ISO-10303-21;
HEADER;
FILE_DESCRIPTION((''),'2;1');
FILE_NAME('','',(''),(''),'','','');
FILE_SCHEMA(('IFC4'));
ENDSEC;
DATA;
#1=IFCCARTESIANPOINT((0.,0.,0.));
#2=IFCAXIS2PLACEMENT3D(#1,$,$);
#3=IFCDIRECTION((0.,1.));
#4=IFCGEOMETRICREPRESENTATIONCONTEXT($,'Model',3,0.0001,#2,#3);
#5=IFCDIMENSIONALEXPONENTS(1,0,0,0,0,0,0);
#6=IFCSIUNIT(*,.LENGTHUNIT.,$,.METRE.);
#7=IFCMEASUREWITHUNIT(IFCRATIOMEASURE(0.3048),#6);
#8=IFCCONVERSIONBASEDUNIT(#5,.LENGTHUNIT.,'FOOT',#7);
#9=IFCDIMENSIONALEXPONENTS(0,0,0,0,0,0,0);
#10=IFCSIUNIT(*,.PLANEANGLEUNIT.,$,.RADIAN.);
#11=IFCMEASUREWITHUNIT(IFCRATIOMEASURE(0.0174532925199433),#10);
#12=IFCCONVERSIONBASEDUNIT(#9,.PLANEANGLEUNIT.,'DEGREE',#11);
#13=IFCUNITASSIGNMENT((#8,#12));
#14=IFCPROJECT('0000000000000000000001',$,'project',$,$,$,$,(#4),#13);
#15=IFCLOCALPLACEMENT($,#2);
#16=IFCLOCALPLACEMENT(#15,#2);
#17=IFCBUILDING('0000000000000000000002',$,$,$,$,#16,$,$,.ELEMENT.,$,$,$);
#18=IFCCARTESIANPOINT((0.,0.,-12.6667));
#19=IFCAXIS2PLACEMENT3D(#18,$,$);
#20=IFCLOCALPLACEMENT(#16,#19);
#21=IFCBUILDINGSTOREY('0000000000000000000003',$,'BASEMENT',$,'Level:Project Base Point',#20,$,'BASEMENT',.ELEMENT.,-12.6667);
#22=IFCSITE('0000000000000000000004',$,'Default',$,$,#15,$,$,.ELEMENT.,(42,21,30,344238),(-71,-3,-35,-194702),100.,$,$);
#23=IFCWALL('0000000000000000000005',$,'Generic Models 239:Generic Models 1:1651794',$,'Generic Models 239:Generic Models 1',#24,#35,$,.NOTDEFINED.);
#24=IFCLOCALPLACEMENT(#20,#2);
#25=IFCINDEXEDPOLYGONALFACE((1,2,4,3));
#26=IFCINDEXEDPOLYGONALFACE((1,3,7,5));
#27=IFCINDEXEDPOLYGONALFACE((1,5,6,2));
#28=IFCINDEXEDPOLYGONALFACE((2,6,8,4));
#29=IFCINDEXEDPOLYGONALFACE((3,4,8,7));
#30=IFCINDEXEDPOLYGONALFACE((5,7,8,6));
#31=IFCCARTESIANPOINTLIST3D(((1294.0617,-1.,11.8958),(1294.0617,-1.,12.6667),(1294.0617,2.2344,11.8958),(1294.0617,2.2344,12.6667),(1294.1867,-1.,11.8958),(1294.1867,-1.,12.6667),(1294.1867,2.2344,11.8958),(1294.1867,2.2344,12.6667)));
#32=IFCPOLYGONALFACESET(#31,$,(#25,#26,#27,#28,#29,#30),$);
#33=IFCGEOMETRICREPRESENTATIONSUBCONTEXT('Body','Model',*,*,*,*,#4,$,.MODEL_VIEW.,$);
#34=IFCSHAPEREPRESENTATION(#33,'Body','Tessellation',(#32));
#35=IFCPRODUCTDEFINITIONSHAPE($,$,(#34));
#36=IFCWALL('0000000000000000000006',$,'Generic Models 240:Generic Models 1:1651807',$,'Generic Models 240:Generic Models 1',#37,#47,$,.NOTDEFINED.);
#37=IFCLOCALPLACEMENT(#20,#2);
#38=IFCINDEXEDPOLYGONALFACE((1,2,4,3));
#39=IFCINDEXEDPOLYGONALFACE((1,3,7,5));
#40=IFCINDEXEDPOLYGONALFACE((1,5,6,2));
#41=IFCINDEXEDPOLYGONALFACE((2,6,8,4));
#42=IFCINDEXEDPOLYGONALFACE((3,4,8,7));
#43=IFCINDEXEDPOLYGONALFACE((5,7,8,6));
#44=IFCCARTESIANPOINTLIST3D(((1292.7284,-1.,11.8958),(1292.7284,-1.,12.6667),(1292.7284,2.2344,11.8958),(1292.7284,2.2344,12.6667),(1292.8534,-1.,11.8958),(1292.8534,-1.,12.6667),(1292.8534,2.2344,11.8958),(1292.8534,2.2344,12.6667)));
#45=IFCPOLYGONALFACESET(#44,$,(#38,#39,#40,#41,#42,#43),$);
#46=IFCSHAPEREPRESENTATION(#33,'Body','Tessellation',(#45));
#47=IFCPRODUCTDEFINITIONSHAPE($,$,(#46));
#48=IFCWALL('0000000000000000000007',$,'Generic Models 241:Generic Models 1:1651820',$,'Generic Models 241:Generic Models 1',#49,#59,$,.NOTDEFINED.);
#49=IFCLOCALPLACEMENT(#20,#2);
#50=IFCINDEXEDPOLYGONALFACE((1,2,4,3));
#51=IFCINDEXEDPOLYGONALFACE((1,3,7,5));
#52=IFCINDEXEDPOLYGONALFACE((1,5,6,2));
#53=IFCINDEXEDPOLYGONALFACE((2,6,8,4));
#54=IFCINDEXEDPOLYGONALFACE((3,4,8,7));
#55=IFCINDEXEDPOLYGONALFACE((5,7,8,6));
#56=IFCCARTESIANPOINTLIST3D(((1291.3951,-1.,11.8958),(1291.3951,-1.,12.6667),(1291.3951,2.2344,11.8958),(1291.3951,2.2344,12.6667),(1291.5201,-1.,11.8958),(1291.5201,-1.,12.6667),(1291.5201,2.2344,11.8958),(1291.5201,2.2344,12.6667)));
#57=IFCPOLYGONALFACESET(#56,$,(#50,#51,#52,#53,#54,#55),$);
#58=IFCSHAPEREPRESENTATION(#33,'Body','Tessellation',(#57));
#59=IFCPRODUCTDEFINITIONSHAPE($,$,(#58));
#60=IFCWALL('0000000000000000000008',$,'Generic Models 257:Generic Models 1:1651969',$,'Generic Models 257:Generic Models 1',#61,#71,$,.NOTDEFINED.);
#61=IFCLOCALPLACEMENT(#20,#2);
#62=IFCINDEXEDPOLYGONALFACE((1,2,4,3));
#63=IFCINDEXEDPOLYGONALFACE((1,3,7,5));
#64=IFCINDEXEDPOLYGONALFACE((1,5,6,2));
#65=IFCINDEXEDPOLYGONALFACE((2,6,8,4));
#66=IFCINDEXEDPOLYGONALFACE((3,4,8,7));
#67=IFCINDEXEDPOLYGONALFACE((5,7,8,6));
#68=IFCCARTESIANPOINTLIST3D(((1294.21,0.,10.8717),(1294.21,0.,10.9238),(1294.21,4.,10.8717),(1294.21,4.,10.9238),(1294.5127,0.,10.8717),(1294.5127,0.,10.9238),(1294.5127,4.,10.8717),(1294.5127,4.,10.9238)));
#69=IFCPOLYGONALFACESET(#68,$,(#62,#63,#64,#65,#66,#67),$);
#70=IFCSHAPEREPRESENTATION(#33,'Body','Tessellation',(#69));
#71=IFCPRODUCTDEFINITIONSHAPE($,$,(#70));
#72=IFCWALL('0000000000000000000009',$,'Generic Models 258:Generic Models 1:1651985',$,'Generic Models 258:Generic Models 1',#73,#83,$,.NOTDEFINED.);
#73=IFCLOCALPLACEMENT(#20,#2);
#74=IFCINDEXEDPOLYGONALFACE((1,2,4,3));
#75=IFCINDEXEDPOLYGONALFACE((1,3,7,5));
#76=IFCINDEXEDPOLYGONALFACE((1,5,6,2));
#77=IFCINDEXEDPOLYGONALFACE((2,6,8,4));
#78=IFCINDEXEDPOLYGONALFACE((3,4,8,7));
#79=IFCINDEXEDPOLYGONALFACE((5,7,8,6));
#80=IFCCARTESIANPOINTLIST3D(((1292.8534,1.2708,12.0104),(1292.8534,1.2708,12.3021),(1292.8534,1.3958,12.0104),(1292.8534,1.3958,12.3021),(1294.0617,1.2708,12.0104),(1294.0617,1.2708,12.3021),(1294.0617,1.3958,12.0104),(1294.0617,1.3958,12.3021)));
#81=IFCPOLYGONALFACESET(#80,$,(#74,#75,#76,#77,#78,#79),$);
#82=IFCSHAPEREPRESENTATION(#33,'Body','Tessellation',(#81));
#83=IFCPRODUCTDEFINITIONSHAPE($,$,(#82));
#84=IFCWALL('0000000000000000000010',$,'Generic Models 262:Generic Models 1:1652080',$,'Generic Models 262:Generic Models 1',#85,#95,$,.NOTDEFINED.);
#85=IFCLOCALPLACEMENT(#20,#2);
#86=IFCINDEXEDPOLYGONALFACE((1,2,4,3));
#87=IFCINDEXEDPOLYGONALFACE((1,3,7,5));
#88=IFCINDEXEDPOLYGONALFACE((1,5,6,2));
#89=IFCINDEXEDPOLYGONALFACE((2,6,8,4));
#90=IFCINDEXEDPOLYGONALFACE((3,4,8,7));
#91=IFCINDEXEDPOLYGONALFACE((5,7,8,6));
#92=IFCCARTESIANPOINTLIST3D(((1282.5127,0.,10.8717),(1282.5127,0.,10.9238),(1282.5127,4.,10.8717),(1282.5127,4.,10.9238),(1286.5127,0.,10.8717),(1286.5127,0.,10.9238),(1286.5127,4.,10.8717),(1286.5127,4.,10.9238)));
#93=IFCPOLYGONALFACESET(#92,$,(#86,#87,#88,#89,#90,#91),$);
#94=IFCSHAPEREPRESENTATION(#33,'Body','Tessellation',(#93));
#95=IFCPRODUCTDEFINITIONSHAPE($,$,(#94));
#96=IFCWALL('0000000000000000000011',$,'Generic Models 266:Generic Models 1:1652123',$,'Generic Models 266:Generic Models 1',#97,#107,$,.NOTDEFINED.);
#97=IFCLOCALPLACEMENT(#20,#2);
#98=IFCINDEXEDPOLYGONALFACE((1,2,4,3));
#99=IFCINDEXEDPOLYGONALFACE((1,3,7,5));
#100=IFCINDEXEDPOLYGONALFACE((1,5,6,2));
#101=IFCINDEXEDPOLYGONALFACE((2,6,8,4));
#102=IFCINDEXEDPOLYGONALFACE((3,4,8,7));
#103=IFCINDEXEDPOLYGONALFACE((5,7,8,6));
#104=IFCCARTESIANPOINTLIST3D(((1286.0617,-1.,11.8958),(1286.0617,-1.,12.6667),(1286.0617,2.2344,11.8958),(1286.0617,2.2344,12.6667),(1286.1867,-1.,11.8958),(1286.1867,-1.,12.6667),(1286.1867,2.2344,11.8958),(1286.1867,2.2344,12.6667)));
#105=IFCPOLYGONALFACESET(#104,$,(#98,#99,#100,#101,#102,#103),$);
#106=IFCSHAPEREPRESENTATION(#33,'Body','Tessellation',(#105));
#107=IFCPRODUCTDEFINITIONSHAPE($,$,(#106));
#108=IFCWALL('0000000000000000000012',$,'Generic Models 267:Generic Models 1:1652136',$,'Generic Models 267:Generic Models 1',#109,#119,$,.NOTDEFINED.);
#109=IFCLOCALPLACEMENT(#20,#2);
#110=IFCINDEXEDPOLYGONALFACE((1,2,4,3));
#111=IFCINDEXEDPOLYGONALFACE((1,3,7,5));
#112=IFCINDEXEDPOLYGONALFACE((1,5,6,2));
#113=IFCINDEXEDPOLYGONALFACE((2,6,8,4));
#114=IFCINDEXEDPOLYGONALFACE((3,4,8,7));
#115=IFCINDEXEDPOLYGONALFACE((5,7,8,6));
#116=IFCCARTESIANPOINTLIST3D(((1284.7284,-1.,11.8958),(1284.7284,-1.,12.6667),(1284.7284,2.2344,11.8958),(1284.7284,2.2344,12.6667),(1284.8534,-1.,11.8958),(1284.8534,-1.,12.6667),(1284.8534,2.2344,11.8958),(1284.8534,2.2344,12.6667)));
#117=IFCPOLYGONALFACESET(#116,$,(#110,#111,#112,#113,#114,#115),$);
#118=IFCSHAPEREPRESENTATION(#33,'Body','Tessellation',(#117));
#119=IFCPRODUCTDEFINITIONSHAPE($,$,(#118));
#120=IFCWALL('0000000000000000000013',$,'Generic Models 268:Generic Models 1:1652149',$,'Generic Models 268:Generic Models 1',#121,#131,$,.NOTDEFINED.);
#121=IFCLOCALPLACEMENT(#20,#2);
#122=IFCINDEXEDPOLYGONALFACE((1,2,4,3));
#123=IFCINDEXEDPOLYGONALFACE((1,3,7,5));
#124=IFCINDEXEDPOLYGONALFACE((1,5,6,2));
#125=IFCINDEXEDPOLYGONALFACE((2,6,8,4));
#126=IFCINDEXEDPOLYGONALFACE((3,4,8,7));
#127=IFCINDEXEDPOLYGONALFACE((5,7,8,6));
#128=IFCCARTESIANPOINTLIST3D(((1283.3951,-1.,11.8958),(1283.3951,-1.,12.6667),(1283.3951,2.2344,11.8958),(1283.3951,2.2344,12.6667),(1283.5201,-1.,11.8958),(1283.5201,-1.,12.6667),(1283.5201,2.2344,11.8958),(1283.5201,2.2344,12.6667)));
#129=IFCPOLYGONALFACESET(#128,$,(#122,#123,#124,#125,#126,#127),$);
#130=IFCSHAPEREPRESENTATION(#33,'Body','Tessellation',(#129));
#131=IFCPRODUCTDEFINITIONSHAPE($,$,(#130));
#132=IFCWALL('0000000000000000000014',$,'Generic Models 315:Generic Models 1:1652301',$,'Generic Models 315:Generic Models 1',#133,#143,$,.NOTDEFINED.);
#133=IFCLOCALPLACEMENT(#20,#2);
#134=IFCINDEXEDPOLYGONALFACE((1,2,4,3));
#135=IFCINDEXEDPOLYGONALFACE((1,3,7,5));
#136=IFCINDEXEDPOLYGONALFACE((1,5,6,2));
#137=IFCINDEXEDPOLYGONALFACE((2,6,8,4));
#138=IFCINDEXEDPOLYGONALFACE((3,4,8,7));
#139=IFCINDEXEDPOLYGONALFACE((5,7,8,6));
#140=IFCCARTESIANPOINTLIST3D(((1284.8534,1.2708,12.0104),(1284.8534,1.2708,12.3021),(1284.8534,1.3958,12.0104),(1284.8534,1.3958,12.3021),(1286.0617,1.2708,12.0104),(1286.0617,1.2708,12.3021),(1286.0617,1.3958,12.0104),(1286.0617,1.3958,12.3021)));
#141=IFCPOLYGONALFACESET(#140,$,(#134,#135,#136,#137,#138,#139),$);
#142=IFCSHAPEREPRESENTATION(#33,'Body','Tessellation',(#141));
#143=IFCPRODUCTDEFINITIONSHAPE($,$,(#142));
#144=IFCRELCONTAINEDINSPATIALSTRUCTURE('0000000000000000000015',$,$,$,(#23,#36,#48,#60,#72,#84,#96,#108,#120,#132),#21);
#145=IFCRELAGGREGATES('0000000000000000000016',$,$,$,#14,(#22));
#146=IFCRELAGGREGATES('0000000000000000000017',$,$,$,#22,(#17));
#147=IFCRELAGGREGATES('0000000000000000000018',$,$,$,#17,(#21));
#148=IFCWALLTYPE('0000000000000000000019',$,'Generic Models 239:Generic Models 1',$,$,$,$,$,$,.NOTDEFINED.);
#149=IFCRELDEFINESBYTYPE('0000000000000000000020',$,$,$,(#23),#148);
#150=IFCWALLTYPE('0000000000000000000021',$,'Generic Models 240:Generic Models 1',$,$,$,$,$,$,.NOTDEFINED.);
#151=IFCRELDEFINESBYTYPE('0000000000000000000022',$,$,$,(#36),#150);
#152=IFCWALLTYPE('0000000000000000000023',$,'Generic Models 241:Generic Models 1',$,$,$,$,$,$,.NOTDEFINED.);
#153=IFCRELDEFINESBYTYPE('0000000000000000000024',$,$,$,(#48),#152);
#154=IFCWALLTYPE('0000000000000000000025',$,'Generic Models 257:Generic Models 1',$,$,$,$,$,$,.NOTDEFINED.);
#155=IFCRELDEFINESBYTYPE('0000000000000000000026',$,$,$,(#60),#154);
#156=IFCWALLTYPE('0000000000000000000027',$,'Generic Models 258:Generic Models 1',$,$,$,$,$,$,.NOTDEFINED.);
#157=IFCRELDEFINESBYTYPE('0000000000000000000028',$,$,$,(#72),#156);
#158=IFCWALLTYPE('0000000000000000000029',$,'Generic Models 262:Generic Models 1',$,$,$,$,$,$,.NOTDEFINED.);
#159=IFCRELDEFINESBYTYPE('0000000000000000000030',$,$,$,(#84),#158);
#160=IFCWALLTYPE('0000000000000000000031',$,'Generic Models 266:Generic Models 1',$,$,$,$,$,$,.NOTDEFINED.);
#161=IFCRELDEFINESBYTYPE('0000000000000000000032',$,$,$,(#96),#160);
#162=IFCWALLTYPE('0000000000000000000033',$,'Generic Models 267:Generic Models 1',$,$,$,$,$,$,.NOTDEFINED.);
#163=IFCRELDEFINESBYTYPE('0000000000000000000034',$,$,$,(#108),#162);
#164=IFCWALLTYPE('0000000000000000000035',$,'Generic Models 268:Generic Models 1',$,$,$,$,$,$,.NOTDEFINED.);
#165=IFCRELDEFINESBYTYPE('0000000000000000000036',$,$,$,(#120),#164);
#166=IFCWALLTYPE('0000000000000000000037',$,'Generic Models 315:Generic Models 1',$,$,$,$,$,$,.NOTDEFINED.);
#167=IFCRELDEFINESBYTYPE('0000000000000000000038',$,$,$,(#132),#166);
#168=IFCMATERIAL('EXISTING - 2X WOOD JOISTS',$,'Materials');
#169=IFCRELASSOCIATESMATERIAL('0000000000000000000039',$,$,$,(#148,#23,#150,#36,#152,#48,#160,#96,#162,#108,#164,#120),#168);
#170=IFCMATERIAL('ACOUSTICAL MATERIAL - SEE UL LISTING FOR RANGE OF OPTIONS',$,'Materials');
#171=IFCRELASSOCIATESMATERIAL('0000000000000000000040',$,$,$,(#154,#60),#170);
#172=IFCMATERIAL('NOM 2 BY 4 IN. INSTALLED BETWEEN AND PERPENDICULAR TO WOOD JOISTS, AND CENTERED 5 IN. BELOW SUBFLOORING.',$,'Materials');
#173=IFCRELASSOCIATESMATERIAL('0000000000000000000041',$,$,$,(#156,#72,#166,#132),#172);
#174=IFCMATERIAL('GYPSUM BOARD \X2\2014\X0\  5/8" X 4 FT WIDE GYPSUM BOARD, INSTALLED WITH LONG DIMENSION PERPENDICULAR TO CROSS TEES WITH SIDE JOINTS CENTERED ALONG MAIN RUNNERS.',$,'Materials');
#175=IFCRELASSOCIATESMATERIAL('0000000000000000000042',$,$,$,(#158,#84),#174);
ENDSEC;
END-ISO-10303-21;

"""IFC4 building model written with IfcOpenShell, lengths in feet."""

from ifc_helpers import new_model, entity, si_unit, converted_unit, direction, frame, frame_2d, origin, origin_2d_with_axis, place, context, subcontext, project, spatial, rectangle, extrude, material, type_object, element, save


model = new_model("IFC4")

# Units and contexts
model_context = context("Model", 3, precision=0.0001, world=origin(), true_north=direction((0.0, 1.0)))
body_context = subcontext(model_context, "Body", "Model", "MODEL_VIEW")
ifc_project = project(units=[converted_unit("LENGTHUNIT", "FOOT", entity("IfcRatioMeasure", 0.3048), si_unit("LENGTHUNIT", "METRE"), dimensions=[1, 0, 0, 0, 0, 0, 0]), converted_unit("PLANEANGLEUNIT", "DEGREE", entity("IfcRatioMeasure", 0.0174532925199433), si_unit("PLANEANGLEUNIT", "RADIAN"), dimensions=[0, 0, 0, 0, 0, 0, 0])], contexts=[model_context])

# Site, building, storey
site_placement = place(None, origin())
site = spatial("IfcSite", under=ifc_project, at=site_placement, Name="Default", CompositionType="ELEMENT", RefLatitude=(42, 21, 30, 344238), RefLongitude=(-71, -3, -35, -194702), RefElevation=100.0)
building_placement = place(site_placement, origin())
building = spatial("IfcBuilding", under=site, at=building_placement, CompositionType="ELEMENT")
storey_placement = place(building_placement, frame((0.0, 0.0, -12.6667)))
storey = spatial("IfcBuildingStorey", under=building, at=storey_placement, Name="BASEMENT", ObjectType="Level:Project Base Point", LongName="BASEMENT", CompositionType="ELEMENT", Elevation=-12.6667)

# Walls
ifc_material_1 = material(Name="ACOUSTICAL MATERIAL - SEE UL LISTING FOR RANGE OF OPTIONS", Category="Materials")
ifc_material_2 = material(Name="EXISTING - 2X WOOD JOISTS", Category="Materials")
wall_type_1 = type_object("IfcWallType", Name="Generic Models 239:Generic Models 1", PredefinedType="NOTDEFINED", material=ifc_material_2)
wall_1_placement = place(storey_placement, frame((1294.0617, -1.0, 11.8958), z_axis=(0.0, 0.0, 1.0), x_axis=(0.0, 1.0, 0.0)))
element("IfcWall", 1, at=wall_1_placement, inside=storey, type_object=wall_type_1, material=ifc_material_2, Name="Generic Models 239:Generic Models 1:1651794", ObjectType="Generic Models 239:Generic Models 1", PredefinedType="NOTDEFINED", context=body_context, shape_type="SweptSolid", body=[
    extrude(rectangle(XDim=3.2344, YDim=0.125, at=frame_2d((0.0, 0.0), x_axis=(1.0, 0.0))), frame((1.6172, -0.0625, 0.0)), (0.0, 0.0, 1.0), 0.7708),
])
wall_type_2 = type_object("IfcWallType", Name="Generic Models 240:Generic Models 1", PredefinedType="NOTDEFINED", material=ifc_material_2)
wall_2_placement = place(storey_placement, frame((1292.7284, -1.0, 11.8958), z_axis=(0.0, 0.0, 1.0), x_axis=(0.0, 1.0, 0.0)))
element("IfcWall", 2, at=wall_2_placement, inside=storey, type_object=wall_type_2, material=ifc_material_2, Name="Generic Models 240:Generic Models 1:1651807", ObjectType="Generic Models 240:Generic Models 1", PredefinedType="NOTDEFINED", context=body_context, shape_type="SweptSolid", body=[
    extrude(rectangle(XDim=3.2344, YDim=0.125, at=frame_2d((0.0, 0.0), x_axis=(1.0, 0.0))), frame((1.6172, -0.0625, 0.0)), (0.0, 0.0, 1.0), 0.7708),
])
wall_type_3 = type_object("IfcWallType", Name="Generic Models 241:Generic Models 1", PredefinedType="NOTDEFINED", material=ifc_material_2)
wall_3_placement = place(storey_placement, frame((1291.3951, -1.0, 11.8958), z_axis=(0.0, 0.0, 1.0), x_axis=(0.0, 1.0, 0.0)))
element("IfcWall", 3, at=wall_3_placement, inside=storey, type_object=wall_type_3, material=ifc_material_2, Name="Generic Models 241:Generic Models 1:1651820", ObjectType="Generic Models 241:Generic Models 1", PredefinedType="NOTDEFINED", context=body_context, shape_type="SweptSolid", body=[
    extrude(rectangle(XDim=3.2344, YDim=0.125, at=frame_2d((0.0, 0.0), x_axis=(1.0, 0.0))), frame((1.6172, -0.0625, 0.0)), (0.0, 0.0, 1.0), 0.7708),
])
wall_type_4 = type_object("IfcWallType", Name="Generic Models 257:Generic Models 1", PredefinedType="NOTDEFINED", material=ifc_material_1)
wall_4_placement = place(storey_placement, frame((1294.21, 0.0, 10.8717), z_axis=(0.0, 0.0, 1.0), x_axis=(0.0, 1.0, 0.0)))
element("IfcWall", 4, at=wall_4_placement, inside=storey, type_object=wall_type_4, material=ifc_material_1, Name="Generic Models 257:Generic Models 1:1651969", ObjectType="Generic Models 257:Generic Models 1", PredefinedType="NOTDEFINED", context=body_context, shape_type="SweptSolid", body=[
    extrude(rectangle(XDim=4.0, YDim=0.3027, at=frame_2d((0.0, 0.0), x_axis=(1.0, 0.0))), frame((2.0, -0.1514, 0.0)), (0.0, 0.0, 1.0), 0.0521),
])
ifc_material_3 = material(Name="NOM 2 BY 4 IN. INSTALLED BETWEEN AND PERPENDICULAR TO WOOD JOISTS, AND CENTERED 5 IN. BELOW SUBFLOORING.", Category="Materials")
wall_type_5 = type_object("IfcWallType", Name="Generic Models 258:Generic Models 1", PredefinedType="NOTDEFINED", material=ifc_material_3)
wall_5_placement = place(storey_placement, frame((1292.8534, 1.2708, 12.0104)))
element("IfcWall", 5, at=wall_5_placement, inside=storey, type_object=wall_type_5, material=ifc_material_3, Name="Generic Models 258:Generic Models 1:1651985", ObjectType="Generic Models 258:Generic Models 1", PredefinedType="NOTDEFINED", context=body_context, shape_type="SweptSolid", body=[
    extrude(rectangle(XDim=0.125, YDim=1.2083, at=frame_2d((0.0, 0.0), x_axis=(1.0, 0.0))), frame((0.6042, 0.0625, 0.0), z_axis=(0.0, 0.0, 1.0), x_axis=(0.0, 1.0, 0.0)), (0.0, 0.0, 1.0), 0.2917),
])
ifc_material_4 = material(Name="GYPSUM BOARD —  5/8\" X 4 FT WIDE GYPSUM BOARD, INSTALLED WITH LONG DIMENSION PERPENDICULAR TO CROSS TEES WITH SIDE JOINTS CENTERED ALONG MAIN RUNNERS.", Category="Materials")
wall_type_6 = type_object("IfcWallType", Name="Generic Models 262:Generic Models 1", PredefinedType="NOTDEFINED", material=ifc_material_4)
wall_6_placement = place(storey_placement, frame((1282.5127, 0.0, 10.8717), z_axis=(0.0, 0.0, 1.0), x_axis=(0.0, 1.0, 0.0)))
element("IfcWall", 6, at=wall_6_placement, inside=storey, type_object=wall_type_6, material=ifc_material_4, Name="Generic Models 262:Generic Models 1:1652080", ObjectType="Generic Models 262:Generic Models 1", PredefinedType="NOTDEFINED", context=body_context, shape_type="SweptSolid", body=[
    extrude(rectangle(XDim=4.0, YDim=4.0, at=origin_2d_with_axis()), frame((2.0, -2.0, 0.0)), (0.0, 0.0, 1.0), 0.0521),
])
wall_type_7 = type_object("IfcWallType", Name="Generic Models 266:Generic Models 1", PredefinedType="NOTDEFINED", material=ifc_material_2)
wall_7_placement = place(storey_placement, frame((1286.0617, -1.0, 11.8958), z_axis=(0.0, 0.0, 1.0), x_axis=(0.0, 1.0, 0.0)))
element("IfcWall", 7, at=wall_7_placement, inside=storey, type_object=wall_type_7, material=ifc_material_2, Name="Generic Models 266:Generic Models 1:1652123", ObjectType="Generic Models 266:Generic Models 1", PredefinedType="NOTDEFINED", context=body_context, shape_type="SweptSolid", body=[
    extrude(rectangle(XDim=3.2344, YDim=0.125, at=frame_2d((0.0, 0.0), x_axis=(1.0, 0.0))), frame((1.6172, -0.0625, 0.0)), (0.0, 0.0, 1.0), 0.7708),
])
wall_type_8 = type_object("IfcWallType", Name="Generic Models 267:Generic Models 1", PredefinedType="NOTDEFINED", material=ifc_material_2)
wall_8_placement = place(storey_placement, frame((1284.7284, -1.0, 11.8958), z_axis=(0.0, 0.0, 1.0), x_axis=(0.0, 1.0, 0.0)))
element("IfcWall", 8, at=wall_8_placement, inside=storey, type_object=wall_type_8, material=ifc_material_2, Name="Generic Models 267:Generic Models 1:1652136", ObjectType="Generic Models 267:Generic Models 1", PredefinedType="NOTDEFINED", context=body_context, shape_type="SweptSolid", body=[
    extrude(rectangle(XDim=3.2344, YDim=0.125, at=frame_2d((0.0, 0.0), x_axis=(1.0, 0.0))), frame((1.6172, -0.0625, 0.0)), (0.0, 0.0, 1.0), 0.7708),
])
wall_type_9 = type_object("IfcWallType", Name="Generic Models 268:Generic Models 1", PredefinedType="NOTDEFINED", material=ifc_material_2)
wall_9_placement = place(storey_placement, frame((1283.3951, -1.0, 11.8958), z_axis=(0.0, 0.0, 1.0), x_axis=(0.0, 1.0, 0.0)))
element("IfcWall", 9, at=wall_9_placement, inside=storey, type_object=wall_type_9, material=ifc_material_2, Name="Generic Models 268:Generic Models 1:1652149", ObjectType="Generic Models 268:Generic Models 1", PredefinedType="NOTDEFINED", context=body_context, shape_type="SweptSolid", body=[
    extrude(rectangle(XDim=3.2344, YDim=0.125, at=frame_2d((0.0, 0.0), x_axis=(1.0, 0.0))), frame((1.6172, -0.0625, 0.0)), (0.0, 0.0, 1.0), 0.7708),
])
wall_type_10 = type_object("IfcWallType", Name="Generic Models 315:Generic Models 1", PredefinedType="NOTDEFINED", material=ifc_material_3)
wall_10_placement = place(storey_placement, frame((1284.8534, 1.2708, 12.0104)))
element("IfcWall", 10, at=wall_10_placement, inside=storey, type_object=wall_type_10, material=ifc_material_3, Name="Generic Models 315:Generic Models 1:1652301", ObjectType="Generic Models 315:Generic Models 1", PredefinedType="NOTDEFINED", context=body_context, shape_type="SweptSolid", body=[
    extrude(rectangle(XDim=0.125, YDim=1.2083, at=frame_2d((0.0, 0.0), x_axis=(1.0, 0.0))), frame((0.6042, 0.0625, 0.0), z_axis=(0.0, 0.0, 1.0), x_axis=(0.0, 1.0, 0.0)), (0.0, 0.0, 1.0), 0.2917),
])

save(model, "model.ifc")
